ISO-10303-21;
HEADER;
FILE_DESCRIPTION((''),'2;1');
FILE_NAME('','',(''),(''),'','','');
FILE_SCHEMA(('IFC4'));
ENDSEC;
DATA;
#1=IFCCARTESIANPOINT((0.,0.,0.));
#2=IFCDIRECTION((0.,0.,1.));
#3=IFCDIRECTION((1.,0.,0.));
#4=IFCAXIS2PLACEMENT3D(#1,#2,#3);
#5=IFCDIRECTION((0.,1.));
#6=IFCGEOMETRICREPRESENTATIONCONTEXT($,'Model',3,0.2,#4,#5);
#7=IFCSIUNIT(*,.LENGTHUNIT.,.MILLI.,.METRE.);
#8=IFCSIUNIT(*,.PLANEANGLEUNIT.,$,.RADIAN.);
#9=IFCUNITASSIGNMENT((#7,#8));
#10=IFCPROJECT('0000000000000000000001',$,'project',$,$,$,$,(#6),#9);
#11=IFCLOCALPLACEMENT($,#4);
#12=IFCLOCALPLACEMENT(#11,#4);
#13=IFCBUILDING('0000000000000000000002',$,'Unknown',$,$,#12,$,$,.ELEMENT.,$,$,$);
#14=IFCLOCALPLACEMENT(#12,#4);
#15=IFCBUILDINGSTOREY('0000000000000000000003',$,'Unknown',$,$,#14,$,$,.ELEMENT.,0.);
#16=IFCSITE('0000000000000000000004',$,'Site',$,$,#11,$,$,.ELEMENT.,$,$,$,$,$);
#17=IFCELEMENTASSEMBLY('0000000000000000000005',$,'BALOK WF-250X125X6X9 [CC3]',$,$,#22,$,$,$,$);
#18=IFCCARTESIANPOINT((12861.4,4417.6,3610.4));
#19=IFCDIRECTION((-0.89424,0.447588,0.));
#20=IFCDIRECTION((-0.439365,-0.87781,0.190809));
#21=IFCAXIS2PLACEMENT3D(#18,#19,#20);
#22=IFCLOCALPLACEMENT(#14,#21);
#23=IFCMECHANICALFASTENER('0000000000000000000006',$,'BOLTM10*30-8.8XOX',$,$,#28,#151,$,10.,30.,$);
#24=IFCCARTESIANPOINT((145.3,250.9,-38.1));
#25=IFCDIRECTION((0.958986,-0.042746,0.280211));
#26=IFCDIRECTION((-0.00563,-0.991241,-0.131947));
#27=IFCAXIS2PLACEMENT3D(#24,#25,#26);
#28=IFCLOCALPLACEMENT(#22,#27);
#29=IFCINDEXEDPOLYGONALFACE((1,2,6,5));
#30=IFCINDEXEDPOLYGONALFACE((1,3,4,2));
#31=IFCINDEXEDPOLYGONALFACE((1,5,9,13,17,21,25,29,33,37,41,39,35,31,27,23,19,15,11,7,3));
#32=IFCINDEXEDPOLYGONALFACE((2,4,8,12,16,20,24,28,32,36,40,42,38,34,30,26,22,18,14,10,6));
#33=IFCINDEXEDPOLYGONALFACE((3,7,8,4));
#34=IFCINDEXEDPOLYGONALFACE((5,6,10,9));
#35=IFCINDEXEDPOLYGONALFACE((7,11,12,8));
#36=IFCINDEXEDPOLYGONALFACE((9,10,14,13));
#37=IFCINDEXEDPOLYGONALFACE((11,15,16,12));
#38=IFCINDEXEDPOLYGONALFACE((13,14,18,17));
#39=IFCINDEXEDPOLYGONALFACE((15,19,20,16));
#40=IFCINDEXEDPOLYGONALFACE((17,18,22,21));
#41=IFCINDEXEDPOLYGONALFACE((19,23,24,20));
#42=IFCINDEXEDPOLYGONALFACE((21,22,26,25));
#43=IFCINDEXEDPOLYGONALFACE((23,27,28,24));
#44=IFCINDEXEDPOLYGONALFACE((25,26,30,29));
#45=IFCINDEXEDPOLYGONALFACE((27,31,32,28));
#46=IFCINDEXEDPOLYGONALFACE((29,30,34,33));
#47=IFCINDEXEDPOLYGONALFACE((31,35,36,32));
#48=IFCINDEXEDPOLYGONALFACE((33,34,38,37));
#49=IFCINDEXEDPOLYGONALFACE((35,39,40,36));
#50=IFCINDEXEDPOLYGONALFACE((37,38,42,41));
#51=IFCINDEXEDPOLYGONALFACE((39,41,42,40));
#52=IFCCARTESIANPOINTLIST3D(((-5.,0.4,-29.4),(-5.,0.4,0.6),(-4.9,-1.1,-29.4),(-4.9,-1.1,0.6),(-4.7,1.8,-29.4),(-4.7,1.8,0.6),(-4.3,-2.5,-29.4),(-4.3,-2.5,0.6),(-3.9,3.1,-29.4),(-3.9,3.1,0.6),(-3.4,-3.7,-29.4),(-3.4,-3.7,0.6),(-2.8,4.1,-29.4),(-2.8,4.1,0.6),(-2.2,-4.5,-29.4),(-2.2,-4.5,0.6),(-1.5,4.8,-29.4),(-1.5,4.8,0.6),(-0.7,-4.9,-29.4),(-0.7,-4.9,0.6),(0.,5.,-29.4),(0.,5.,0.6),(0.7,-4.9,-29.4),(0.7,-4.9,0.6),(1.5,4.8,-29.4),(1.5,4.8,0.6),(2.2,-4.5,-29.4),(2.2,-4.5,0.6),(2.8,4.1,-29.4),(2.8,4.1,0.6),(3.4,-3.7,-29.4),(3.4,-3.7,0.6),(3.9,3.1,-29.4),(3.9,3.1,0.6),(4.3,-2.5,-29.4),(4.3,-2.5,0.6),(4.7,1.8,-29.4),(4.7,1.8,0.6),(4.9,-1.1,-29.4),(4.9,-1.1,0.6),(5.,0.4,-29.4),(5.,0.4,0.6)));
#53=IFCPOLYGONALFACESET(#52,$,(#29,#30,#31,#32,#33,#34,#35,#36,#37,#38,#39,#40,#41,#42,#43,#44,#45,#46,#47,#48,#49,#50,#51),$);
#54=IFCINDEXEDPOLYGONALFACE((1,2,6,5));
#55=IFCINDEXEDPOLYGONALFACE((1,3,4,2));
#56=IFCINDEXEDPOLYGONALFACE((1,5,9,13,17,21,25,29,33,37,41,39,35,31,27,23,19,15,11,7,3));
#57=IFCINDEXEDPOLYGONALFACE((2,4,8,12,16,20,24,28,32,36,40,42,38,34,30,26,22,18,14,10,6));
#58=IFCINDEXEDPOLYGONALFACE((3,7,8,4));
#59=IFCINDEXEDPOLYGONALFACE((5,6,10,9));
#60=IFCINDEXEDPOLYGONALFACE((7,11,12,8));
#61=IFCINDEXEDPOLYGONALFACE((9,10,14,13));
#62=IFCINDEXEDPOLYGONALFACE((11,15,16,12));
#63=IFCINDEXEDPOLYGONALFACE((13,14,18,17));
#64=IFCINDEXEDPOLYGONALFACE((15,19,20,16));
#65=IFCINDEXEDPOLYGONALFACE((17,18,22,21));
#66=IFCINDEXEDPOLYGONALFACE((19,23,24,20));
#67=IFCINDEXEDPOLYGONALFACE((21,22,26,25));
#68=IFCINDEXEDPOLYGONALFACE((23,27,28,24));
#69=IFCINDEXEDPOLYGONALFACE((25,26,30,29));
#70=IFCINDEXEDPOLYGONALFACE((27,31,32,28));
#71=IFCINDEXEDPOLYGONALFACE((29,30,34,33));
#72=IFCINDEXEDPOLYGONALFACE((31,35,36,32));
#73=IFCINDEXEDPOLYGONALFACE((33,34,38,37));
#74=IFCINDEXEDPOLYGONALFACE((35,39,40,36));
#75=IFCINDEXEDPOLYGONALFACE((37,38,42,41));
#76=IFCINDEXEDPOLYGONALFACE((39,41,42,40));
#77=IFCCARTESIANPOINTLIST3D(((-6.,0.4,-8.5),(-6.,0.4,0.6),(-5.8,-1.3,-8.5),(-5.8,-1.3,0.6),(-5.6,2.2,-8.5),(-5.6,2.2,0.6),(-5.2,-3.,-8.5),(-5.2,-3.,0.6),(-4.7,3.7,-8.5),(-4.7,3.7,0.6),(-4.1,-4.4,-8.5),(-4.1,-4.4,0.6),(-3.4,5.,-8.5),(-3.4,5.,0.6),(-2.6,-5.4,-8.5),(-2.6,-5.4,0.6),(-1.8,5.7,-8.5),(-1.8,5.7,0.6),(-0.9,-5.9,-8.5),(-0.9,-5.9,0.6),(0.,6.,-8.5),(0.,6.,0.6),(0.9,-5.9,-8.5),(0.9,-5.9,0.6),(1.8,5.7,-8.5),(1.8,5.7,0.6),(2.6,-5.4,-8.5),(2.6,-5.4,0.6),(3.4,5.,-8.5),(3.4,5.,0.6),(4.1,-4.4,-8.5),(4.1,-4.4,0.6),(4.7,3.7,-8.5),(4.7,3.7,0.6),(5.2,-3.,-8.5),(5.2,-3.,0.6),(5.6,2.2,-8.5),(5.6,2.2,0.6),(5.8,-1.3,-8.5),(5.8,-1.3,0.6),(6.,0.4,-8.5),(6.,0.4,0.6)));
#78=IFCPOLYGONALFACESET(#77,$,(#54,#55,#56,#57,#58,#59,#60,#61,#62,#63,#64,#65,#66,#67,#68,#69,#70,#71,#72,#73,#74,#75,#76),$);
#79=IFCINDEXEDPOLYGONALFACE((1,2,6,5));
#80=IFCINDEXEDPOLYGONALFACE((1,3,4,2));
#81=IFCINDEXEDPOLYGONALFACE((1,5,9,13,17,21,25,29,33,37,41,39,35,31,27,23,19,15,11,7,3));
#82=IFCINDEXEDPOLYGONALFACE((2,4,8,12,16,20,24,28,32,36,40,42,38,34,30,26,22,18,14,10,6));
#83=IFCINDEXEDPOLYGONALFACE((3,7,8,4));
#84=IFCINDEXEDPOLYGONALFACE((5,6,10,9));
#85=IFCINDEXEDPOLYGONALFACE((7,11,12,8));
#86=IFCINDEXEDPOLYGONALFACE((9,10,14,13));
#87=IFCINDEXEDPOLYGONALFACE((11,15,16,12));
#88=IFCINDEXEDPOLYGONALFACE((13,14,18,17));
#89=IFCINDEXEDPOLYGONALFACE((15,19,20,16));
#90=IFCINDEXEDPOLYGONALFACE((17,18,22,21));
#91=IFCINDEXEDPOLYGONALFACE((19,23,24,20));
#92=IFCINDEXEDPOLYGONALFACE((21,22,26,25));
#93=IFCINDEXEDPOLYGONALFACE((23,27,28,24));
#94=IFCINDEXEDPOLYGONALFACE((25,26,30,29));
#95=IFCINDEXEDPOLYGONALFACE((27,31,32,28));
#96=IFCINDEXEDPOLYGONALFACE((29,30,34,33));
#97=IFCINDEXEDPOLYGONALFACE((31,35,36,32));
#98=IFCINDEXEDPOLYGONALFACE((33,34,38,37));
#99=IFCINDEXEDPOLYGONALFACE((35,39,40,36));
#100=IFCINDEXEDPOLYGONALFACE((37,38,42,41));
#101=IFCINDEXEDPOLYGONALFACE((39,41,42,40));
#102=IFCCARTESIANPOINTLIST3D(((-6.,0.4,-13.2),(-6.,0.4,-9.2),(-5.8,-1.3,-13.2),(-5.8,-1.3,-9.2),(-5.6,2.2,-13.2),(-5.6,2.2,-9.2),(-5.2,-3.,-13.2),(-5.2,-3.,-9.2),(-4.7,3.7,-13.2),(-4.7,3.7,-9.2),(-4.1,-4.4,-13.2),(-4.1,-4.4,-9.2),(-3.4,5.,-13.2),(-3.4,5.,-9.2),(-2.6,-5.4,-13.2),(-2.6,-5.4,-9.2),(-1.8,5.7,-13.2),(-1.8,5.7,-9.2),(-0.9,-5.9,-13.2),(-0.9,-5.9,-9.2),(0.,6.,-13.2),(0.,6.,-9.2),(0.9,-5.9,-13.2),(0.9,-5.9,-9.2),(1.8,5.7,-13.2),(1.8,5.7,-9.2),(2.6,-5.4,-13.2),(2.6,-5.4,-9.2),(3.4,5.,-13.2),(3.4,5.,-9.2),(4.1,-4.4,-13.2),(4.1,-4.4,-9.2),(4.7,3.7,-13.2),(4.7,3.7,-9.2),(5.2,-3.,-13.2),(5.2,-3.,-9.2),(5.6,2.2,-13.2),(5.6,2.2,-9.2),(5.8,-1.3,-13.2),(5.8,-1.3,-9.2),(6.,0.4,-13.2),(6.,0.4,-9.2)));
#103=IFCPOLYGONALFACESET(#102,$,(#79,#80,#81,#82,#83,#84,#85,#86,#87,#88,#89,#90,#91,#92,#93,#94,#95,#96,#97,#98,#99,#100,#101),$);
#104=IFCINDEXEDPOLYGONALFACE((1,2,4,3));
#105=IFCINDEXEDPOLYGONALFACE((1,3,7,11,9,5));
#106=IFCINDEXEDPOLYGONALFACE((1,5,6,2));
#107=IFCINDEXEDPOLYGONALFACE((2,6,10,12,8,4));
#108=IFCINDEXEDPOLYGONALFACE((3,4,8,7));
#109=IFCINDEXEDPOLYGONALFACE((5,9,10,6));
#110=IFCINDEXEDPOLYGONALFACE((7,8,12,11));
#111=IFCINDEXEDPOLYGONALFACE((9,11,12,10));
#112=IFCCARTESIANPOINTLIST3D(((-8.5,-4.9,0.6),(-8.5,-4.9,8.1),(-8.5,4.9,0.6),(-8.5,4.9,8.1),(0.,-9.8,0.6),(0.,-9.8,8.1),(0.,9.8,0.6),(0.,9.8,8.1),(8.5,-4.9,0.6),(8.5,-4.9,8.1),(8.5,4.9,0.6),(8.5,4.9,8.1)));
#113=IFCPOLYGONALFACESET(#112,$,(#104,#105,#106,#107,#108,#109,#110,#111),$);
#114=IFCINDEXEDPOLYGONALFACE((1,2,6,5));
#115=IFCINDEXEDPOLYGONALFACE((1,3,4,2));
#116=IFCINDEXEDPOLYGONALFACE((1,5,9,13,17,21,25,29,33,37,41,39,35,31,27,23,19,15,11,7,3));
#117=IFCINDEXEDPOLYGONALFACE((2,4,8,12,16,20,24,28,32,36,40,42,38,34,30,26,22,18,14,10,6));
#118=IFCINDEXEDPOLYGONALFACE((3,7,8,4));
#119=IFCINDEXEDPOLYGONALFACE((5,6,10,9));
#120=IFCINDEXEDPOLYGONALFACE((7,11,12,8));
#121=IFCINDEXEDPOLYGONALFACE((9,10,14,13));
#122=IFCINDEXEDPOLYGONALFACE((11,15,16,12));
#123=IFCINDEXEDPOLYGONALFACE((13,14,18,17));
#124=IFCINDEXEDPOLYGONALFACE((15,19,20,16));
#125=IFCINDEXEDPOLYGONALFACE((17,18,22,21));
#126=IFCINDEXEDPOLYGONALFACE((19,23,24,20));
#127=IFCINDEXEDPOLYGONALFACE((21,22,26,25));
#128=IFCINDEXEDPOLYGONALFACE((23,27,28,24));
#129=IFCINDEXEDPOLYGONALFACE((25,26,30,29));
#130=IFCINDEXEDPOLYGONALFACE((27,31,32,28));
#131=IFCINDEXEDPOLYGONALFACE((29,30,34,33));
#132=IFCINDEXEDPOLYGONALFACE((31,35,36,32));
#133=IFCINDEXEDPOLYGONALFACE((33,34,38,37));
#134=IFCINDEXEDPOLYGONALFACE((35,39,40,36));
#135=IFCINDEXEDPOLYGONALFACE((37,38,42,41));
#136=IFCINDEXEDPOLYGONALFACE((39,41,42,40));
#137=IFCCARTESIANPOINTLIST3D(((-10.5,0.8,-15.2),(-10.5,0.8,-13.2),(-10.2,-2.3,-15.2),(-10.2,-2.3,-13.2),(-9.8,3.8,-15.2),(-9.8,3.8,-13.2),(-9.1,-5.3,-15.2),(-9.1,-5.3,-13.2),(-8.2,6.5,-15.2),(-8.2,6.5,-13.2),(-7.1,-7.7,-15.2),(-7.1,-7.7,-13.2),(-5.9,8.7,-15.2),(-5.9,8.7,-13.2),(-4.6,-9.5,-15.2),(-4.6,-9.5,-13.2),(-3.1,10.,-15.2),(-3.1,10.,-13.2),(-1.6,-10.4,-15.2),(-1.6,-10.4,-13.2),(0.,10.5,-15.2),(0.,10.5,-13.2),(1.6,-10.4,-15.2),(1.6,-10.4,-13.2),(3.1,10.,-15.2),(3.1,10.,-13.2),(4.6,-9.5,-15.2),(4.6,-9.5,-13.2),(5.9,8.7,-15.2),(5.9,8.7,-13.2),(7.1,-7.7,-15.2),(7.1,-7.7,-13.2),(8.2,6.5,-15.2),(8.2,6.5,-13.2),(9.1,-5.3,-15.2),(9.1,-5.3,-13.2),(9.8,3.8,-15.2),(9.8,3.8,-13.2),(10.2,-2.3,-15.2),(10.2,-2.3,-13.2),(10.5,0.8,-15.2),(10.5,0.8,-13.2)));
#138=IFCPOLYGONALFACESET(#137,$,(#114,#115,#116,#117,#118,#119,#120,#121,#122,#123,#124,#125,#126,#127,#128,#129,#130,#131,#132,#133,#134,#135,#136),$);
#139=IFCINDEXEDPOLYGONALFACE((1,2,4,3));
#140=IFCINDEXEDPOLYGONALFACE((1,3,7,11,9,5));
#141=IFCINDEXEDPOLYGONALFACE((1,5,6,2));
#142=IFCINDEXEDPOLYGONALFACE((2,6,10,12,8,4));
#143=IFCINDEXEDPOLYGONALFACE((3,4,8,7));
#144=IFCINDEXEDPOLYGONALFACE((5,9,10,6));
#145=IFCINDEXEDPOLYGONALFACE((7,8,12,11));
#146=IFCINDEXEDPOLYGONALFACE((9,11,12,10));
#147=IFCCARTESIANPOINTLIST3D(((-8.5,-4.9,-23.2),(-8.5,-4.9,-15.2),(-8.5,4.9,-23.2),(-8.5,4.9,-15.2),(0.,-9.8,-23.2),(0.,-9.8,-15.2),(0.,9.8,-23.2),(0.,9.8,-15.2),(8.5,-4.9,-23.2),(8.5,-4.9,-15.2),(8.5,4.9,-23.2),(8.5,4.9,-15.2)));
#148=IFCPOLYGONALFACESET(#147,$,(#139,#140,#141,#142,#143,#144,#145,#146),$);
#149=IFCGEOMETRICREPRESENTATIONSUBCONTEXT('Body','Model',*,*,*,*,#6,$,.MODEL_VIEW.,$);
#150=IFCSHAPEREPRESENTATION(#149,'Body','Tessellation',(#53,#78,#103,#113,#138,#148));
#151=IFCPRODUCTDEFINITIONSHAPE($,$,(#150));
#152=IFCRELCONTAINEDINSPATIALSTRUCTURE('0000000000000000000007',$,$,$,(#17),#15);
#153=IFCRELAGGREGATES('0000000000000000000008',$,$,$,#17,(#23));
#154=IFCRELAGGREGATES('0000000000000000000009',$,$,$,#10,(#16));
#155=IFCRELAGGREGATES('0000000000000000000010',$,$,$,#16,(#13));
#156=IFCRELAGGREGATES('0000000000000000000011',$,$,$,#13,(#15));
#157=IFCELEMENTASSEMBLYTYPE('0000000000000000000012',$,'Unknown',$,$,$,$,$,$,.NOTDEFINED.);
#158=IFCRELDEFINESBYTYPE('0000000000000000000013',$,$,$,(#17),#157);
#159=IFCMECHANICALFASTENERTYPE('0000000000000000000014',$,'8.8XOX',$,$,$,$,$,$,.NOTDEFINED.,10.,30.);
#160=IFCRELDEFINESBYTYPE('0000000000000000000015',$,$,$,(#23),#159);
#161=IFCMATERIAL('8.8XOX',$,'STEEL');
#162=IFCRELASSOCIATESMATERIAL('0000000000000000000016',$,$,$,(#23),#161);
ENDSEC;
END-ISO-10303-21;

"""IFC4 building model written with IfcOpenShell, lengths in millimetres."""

from ifc_helpers import new_model, si_unit, direction, frame, origin_with_axes, origin_2d_with_axis, place, context, subcontext, project, spatial, polyline, circle, outline, extrude, source, transform, mapped, material, type_object, element, aggregate, save


model = new_model("IFC4")

# Units and contexts
model_context = context("Model", 3, precision=0.2, world=origin_with_axes(), true_north=direction((0.0, 1.0)))
body_context = subcontext(model_context, "Body", "Model", "MODEL_VIEW")
ifc_project = project(units=[si_unit("LENGTHUNIT", "METRE", prefix="MILLI"), si_unit("PLANEANGLEUNIT", "RADIAN")], contexts=[model_context])

# Site, building, storey
site_placement = place(None, origin_with_axes())
site = spatial("IfcSite", under=ifc_project, at=site_placement, Name="Site", CompositionType="ELEMENT")
building_placement = place(site_placement, origin_with_axes())
building = spatial("IfcBuilding", under=site, at=building_placement, Name="Unknown", CompositionType="ELEMENT")
storey_placement = place(building_placement, origin_with_axes())
storey = spatial("IfcBuildingStorey", under=building, at=storey_placement, Name="Unknown", CompositionType="ELEMENT", Elevation=0.0)

# Element assembly
element_assembly_type = type_object("IfcElementAssemblyType", Name="Unknown", PredefinedType="NOTDEFINED")
assembly_1_placement = place(storey_placement, frame((12861.4, 4417.6, 3610.4), z_axis=(-0.89424, 0.447588, 0.0), x_axis=(-0.439365, -0.87781, 0.190809)))
assembly_1 = element("IfcElementAssembly", 1, at=assembly_1_placement, inside=storey, type_object=element_assembly_type, Name="BALOK WF-250X125X6X9 [CC3]")

# Mechanical fastener
ifc_material_1 = material(Name="8.8XOX", Category="STEEL")
mechanical_fastener_type_1 = type_object("IfcMechanicalFastenerType", Name="8.8XOX", NominalDiameter=10.0, NominalLength=30.0, PredefinedType="NOTDEFINED")
shared_shape_1 = source(origin_with_axes(), body_context, "Body", "SweptSolid", [
    extrude(circle(Radius=5.0, at=origin_2d_with_axis()), frame((0.0, 0.0, 0.6), z_axis=(0.0, 0.0, -1.0), x_axis=(0.0, 1.0, 0.0)), (0.0, 0.0, 1.0), 30.0),
    extrude(circle(Radius=6.0, at=origin_2d_with_axis()), frame((0.0, 0.0, 0.6), z_axis=(0.0, 0.0, -1.0), x_axis=(0.0, 1.0, 0.0)), (0.0, 0.0, 1.0), 9.1),
    extrude(circle(Radius=6.0, at=origin_2d_with_axis()), frame((0.0, 0.0, -9.2), z_axis=(0.0, 0.0, -1.0), x_axis=(0.0, 1.0, 0.0)), (0.0, 0.0, 1.0), 4.0),
    extrude(outline(polyline([(9.8, 0.0), (4.9, 8.5), (-4.9, 8.5), (-9.8, 0.0), (-4.9, -8.5), (4.9, -8.5), (9.8, 0.0)])), frame((0.0, 0.0, 8.1), z_axis=(0.0, 0.0, -1.0), x_axis=(0.0, 1.0, 0.0)), (0.0, 0.0, 1.0), 7.5),
    extrude(circle(Radius=10.5, at=origin_2d_with_axis()), frame((0.0, 0.0, -13.2), z_axis=(0.0, 0.0, -1.0), x_axis=(0.0, 1.0, 0.0)), (0.0, 0.0, 1.0), 2.0),
    extrude(outline(polyline([(9.8, 0.0), (4.9, 8.5), (-4.9, 8.5), (-9.8, 0.0), (-4.9, -8.5), (4.9, -8.5), (9.8, 0.0)])), frame((0.0, 0.0, -15.2), z_axis=(0.0, 0.0, -1.0), x_axis=(0.0, 1.0, 0.0)), (0.0, 0.0, 1.0), 8.0),
])
mechanical_fastener_1_placement = place(assembly_1_placement, frame((145.3, 250.9, -38.1), z_axis=(0.958986, -0.042746, 0.280211), x_axis=(-0.00563, -0.991241, -0.131947)))
mechanical_fastener_1 = element("IfcMechanicalFastener", 2, at=mechanical_fastener_1_placement, type_object=mechanical_fastener_type_1, material=ifc_material_1, Name="BOLTM10*30-8.8XOX", NominalDiameter=10.0, NominalLength=30.0, context=body_context, shape_type="MappedRepresentation", body=[
    mapped(shared_shape_1, transform((0.0, 0.0, 0.0))),
])
aggregate(assembly_1, [mechanical_fastener_1])

save(model, "model.ifc")
